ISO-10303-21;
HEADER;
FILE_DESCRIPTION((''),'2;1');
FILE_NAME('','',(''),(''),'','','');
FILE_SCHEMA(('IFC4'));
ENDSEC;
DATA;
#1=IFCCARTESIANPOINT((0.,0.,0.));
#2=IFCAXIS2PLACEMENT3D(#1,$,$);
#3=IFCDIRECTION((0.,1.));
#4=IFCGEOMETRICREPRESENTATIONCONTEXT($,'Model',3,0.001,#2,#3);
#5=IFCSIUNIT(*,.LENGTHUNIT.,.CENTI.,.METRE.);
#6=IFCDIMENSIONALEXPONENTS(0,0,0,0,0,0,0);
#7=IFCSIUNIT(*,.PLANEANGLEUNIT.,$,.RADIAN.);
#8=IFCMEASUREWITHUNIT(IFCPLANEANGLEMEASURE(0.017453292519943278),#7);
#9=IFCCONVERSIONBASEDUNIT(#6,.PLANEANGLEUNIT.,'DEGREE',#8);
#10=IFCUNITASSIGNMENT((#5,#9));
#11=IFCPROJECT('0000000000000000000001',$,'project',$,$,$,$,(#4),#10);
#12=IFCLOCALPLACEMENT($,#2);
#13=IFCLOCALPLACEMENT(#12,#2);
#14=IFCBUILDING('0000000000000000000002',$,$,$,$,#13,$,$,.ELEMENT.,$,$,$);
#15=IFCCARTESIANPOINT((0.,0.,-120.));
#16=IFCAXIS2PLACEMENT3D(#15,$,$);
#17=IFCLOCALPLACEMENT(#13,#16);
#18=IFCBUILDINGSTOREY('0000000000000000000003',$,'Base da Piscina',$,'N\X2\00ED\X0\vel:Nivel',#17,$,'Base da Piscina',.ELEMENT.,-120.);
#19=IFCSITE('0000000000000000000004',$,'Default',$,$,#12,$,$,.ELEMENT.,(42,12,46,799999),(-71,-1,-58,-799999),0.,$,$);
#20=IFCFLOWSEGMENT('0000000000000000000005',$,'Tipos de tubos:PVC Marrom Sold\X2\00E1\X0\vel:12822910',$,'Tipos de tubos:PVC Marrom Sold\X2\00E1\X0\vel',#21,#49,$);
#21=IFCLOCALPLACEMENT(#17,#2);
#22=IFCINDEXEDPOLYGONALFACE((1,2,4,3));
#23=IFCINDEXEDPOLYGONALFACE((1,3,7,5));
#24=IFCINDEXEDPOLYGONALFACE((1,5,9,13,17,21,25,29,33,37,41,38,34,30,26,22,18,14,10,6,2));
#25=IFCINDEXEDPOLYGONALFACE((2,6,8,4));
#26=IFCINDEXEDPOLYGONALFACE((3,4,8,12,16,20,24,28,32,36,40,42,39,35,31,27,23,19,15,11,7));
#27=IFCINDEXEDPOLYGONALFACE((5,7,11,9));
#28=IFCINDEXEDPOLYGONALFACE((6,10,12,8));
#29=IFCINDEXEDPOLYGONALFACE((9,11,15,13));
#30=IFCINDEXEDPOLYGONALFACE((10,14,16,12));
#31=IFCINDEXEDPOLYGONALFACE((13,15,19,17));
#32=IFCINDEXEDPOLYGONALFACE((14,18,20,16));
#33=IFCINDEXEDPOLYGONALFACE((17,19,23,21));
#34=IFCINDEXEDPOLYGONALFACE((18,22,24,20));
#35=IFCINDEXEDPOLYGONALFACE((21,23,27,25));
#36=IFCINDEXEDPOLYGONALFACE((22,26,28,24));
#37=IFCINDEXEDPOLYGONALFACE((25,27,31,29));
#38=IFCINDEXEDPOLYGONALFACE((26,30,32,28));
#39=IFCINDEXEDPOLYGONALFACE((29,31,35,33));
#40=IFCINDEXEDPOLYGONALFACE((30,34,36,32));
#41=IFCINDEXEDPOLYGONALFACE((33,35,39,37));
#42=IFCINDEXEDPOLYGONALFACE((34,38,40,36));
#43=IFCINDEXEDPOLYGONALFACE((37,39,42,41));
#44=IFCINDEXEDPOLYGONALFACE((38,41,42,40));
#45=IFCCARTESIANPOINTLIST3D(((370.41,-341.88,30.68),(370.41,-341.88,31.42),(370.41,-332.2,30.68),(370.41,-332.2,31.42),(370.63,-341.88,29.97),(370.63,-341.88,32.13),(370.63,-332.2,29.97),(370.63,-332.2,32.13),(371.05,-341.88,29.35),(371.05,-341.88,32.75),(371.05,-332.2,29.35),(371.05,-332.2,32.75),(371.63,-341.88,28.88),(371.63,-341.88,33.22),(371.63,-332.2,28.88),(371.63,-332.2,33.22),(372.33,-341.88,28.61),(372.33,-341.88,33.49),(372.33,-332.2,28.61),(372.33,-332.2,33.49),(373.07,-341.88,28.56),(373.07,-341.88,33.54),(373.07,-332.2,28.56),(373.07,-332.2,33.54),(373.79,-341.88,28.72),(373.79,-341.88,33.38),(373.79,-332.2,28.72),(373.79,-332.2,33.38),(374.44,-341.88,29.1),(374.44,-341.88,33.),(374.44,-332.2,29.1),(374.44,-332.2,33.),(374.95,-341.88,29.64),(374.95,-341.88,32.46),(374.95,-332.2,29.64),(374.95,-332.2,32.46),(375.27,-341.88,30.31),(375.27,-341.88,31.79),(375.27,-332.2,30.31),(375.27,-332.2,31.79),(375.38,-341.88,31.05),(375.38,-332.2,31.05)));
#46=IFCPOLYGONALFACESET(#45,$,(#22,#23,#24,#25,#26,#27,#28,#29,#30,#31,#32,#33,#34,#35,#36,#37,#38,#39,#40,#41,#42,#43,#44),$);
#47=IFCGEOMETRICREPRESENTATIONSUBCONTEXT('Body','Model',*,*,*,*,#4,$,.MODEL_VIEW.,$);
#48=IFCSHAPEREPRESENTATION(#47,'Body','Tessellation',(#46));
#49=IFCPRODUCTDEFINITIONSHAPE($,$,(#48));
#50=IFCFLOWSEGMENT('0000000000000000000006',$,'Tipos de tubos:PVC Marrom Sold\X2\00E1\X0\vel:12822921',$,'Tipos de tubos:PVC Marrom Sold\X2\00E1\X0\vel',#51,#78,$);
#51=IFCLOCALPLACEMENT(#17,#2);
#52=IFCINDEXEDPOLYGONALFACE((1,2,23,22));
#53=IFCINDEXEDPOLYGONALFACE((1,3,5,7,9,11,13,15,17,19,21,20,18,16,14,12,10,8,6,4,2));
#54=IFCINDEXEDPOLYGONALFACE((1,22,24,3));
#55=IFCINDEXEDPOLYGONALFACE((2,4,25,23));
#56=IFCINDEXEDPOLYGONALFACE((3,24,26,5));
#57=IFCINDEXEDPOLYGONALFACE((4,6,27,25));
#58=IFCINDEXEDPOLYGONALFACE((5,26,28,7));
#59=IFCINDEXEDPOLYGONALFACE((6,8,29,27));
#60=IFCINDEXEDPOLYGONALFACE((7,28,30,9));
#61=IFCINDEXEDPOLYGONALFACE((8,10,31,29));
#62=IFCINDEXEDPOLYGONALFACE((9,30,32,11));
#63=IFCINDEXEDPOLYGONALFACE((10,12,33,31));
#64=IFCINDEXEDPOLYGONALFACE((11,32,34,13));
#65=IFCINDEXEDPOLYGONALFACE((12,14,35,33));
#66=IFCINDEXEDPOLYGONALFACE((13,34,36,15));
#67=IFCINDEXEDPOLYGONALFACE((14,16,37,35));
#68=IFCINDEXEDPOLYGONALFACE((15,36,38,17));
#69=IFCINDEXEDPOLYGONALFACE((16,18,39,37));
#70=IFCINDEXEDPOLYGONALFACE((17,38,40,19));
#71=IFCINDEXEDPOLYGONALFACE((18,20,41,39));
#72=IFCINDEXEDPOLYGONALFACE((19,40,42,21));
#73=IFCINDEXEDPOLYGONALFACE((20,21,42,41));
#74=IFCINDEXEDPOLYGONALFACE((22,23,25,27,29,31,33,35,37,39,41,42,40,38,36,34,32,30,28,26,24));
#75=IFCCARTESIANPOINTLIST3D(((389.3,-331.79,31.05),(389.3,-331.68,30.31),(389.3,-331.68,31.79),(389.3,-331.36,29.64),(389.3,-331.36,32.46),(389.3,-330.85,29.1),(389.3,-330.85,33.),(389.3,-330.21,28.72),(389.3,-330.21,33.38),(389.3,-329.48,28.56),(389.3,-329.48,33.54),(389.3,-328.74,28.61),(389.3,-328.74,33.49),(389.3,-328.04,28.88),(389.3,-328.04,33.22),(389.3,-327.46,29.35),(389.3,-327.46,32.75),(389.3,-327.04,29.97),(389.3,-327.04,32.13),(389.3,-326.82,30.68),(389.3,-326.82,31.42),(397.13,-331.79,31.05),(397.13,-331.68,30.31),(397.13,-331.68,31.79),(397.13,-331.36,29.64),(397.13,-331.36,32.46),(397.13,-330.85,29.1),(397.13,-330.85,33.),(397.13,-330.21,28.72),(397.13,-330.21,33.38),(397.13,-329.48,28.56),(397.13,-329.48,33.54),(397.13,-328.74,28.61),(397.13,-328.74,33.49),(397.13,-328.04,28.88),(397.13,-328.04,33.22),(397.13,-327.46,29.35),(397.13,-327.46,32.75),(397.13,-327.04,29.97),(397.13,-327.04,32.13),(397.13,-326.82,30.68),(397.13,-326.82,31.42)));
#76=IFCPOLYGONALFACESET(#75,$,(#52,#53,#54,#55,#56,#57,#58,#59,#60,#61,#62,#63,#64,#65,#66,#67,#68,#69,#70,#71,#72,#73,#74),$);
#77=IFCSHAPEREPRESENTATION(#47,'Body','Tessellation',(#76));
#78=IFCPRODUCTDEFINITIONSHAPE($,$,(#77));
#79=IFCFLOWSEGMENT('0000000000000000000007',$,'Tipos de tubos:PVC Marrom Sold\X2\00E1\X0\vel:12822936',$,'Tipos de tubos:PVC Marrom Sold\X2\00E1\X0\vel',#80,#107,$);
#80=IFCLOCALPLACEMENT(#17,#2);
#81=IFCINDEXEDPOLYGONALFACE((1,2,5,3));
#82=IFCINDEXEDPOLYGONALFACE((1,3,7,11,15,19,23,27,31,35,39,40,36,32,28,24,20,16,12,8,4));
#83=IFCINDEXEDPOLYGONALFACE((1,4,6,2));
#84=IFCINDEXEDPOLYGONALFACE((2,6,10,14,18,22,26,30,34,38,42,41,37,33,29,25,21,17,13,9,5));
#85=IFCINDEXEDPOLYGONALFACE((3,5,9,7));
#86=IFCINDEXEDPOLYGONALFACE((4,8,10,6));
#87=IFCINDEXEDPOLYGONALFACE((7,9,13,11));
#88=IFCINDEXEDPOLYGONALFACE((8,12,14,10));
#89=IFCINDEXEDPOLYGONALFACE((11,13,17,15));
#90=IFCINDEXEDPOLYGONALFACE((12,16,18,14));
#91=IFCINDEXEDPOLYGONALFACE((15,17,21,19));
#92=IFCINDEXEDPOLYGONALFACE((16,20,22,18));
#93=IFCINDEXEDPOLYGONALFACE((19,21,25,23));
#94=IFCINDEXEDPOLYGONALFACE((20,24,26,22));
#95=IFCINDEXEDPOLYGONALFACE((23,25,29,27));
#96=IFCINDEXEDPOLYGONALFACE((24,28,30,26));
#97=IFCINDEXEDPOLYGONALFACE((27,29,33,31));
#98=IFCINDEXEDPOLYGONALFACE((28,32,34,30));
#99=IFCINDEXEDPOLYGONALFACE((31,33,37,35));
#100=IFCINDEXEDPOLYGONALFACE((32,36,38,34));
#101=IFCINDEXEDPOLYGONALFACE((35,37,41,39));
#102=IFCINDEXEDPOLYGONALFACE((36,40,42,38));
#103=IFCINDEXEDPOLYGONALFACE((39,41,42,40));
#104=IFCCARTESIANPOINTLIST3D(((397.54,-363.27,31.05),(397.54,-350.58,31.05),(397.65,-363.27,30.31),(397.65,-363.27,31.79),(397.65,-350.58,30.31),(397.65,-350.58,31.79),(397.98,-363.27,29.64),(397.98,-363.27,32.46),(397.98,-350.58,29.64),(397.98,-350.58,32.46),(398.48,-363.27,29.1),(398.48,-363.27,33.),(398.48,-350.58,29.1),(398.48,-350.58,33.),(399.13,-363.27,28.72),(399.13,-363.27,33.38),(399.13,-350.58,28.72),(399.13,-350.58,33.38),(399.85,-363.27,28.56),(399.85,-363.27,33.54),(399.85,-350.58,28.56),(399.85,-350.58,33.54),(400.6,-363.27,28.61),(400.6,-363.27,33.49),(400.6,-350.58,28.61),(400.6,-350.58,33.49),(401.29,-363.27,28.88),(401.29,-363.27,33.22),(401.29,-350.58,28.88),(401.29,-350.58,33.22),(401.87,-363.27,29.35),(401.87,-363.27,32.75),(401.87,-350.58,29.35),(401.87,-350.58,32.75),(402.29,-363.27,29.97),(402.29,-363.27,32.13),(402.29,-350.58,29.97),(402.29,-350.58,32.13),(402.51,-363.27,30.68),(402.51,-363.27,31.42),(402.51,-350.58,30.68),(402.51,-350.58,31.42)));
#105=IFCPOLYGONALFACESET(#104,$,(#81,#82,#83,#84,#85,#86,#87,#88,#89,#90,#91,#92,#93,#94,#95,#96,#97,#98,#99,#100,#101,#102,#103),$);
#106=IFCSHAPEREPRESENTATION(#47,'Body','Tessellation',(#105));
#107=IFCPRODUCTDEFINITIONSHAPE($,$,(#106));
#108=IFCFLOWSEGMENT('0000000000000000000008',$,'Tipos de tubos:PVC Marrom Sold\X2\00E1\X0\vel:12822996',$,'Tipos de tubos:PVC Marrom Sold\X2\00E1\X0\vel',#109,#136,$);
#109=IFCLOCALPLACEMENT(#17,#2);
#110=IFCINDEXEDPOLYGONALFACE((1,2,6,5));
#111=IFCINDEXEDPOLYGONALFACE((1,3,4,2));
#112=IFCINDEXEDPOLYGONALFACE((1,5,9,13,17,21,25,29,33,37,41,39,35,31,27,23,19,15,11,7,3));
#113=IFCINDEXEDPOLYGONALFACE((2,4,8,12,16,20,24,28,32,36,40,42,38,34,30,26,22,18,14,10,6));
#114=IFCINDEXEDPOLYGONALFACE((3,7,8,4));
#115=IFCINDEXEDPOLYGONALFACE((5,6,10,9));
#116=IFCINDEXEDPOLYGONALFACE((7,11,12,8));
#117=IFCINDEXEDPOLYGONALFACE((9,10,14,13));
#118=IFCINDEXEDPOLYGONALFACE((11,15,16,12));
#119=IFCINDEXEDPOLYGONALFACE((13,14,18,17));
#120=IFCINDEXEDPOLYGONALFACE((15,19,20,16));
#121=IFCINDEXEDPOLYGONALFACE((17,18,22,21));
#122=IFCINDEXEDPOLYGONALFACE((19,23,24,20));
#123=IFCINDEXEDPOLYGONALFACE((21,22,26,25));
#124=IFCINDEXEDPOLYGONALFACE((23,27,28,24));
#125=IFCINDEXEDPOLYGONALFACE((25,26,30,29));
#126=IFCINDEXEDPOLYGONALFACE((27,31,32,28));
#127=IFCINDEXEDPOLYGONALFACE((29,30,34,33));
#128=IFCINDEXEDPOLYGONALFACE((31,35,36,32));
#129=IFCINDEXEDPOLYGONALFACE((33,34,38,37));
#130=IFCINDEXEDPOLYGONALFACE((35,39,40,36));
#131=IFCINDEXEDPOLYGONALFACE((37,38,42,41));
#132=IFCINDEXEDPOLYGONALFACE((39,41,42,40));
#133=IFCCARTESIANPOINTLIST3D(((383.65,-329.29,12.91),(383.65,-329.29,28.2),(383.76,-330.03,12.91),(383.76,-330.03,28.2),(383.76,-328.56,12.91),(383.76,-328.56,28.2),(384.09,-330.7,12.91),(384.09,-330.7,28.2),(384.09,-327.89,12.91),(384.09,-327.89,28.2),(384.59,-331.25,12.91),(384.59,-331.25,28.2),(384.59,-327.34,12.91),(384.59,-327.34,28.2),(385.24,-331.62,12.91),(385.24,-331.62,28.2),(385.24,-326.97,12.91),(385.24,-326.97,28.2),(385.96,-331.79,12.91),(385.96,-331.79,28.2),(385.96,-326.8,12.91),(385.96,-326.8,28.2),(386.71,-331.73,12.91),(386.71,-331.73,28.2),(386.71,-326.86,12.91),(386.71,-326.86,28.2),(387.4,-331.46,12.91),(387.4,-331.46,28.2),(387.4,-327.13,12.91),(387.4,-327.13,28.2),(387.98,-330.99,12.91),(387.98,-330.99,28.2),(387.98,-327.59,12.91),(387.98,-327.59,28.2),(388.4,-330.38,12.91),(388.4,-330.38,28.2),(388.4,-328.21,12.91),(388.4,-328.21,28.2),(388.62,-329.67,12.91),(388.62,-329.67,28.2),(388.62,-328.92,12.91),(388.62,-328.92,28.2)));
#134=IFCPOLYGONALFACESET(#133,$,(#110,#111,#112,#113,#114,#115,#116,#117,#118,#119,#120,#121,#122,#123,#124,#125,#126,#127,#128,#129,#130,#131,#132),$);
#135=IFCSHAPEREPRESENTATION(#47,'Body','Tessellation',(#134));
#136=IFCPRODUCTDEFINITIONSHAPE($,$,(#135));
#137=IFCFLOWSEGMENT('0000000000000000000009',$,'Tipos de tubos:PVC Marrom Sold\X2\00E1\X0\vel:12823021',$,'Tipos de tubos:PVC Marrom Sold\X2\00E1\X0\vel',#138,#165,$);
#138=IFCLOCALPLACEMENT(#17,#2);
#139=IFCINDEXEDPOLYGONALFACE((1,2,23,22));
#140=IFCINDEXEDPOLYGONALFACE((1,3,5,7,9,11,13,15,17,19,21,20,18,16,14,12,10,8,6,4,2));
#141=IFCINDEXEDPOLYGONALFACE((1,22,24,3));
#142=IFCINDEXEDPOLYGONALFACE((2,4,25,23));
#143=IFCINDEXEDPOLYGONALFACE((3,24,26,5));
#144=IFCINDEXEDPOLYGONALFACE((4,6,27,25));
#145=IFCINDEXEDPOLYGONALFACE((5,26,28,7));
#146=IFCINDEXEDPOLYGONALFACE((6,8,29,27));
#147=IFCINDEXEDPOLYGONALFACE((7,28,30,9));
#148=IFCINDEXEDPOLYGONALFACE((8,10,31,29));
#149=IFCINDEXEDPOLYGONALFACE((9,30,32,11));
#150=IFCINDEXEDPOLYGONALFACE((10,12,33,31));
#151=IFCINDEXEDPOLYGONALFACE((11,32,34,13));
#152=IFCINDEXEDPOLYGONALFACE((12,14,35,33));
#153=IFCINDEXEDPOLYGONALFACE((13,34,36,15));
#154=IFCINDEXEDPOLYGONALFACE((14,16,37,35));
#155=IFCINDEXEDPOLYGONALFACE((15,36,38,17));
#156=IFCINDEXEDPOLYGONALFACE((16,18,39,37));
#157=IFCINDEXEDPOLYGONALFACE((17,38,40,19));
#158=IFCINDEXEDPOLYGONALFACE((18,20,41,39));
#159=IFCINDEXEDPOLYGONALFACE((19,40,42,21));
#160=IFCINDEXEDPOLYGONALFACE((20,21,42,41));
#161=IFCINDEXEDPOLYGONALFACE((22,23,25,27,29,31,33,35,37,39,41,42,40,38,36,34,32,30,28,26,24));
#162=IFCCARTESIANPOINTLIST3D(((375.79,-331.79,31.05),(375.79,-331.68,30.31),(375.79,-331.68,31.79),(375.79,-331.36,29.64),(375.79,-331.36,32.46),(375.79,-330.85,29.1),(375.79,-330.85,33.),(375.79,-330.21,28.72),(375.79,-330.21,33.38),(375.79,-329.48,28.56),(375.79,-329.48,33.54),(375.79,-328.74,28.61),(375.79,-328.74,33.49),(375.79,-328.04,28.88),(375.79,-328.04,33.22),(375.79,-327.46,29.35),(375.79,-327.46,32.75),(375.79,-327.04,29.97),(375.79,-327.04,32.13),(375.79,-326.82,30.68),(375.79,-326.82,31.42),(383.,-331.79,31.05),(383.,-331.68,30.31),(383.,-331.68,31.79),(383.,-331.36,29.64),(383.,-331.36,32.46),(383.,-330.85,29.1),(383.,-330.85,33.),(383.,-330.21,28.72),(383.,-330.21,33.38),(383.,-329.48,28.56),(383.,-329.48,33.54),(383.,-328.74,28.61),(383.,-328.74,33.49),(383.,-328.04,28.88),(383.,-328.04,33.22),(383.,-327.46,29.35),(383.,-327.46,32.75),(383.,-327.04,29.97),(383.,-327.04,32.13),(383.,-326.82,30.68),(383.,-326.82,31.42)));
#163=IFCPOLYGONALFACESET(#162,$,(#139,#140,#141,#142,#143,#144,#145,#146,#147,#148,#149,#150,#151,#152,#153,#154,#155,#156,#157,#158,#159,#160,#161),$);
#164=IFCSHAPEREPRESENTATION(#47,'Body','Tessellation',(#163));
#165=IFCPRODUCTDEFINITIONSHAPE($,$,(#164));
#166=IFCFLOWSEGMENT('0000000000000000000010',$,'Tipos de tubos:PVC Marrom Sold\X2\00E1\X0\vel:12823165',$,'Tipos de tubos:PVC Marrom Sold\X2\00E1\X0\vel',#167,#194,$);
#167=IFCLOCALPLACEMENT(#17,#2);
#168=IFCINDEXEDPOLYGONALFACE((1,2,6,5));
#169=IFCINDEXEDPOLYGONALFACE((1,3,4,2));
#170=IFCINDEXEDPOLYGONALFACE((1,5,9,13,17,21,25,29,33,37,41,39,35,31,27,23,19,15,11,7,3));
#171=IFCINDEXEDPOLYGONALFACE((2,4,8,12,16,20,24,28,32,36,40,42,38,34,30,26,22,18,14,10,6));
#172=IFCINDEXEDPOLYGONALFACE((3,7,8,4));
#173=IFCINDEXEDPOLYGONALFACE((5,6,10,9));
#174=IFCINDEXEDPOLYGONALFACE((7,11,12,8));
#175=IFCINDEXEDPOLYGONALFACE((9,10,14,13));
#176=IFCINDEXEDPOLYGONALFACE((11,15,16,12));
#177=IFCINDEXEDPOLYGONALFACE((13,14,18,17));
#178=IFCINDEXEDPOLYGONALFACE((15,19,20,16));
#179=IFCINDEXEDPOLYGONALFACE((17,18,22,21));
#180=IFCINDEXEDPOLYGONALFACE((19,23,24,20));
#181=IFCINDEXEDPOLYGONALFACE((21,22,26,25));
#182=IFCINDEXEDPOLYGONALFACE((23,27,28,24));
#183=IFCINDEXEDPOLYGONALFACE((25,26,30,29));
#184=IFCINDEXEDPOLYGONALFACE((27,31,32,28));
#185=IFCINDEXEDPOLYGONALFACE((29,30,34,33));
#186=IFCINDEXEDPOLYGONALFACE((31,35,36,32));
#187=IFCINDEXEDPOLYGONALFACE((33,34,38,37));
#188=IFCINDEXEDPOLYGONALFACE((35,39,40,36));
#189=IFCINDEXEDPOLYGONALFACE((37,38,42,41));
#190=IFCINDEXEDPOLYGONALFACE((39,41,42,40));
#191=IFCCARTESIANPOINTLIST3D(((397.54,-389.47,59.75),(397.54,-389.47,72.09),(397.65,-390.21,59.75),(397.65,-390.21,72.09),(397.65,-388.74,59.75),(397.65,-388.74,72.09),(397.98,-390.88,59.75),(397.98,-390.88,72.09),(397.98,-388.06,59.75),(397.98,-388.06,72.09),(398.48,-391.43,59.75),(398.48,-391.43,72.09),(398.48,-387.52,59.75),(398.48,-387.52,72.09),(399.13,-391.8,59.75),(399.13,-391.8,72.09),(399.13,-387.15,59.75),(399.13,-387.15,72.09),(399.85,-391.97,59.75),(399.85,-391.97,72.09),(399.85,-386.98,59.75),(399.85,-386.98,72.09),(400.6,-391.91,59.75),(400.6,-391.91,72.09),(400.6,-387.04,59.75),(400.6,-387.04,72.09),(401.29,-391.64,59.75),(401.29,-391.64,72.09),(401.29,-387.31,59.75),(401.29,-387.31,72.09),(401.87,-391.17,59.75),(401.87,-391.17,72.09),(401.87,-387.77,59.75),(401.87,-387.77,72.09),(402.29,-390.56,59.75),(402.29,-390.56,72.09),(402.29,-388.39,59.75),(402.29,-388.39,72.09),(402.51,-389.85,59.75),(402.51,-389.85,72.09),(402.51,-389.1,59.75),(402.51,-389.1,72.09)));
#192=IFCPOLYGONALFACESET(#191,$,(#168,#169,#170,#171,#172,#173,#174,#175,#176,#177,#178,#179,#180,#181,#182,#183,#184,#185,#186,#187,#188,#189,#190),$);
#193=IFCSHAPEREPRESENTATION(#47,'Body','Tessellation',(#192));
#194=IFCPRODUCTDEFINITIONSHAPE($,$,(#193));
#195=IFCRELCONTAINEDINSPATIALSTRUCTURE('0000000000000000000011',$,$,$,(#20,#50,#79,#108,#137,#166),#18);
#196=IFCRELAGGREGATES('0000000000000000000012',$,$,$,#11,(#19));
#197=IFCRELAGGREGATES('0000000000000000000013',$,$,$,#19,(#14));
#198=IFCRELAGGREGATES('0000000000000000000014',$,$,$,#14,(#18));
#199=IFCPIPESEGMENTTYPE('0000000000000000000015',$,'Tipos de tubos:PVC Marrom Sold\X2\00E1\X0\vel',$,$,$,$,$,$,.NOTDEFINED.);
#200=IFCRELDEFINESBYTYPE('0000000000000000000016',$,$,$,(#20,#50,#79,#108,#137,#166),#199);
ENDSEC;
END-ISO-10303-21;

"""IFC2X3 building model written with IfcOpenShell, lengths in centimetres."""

from ifc_helpers import new_model, entity, si_unit, converted_unit, direction, frame, frame_2d, origin, origin_2d_with_axis, place, context, subcontext, project, spatial, circle, extrude, type_object, element, save


model = new_model("IFC2X3")

# Units and contexts
model_context = context("Model", 3, precision=0.001, world=origin(), true_north=direction((0.0, 1.0)))
body_context = subcontext(model_context, "Body", "Model", "MODEL_VIEW")
ifc_project = project(units=[si_unit("LENGTHUNIT", "METRE", prefix="CENTI"), converted_unit("PLANEANGLEUNIT", "DEGREE", entity("IfcPlaneAngleMeasure", 0.017453292519943278), si_unit("PLANEANGLEUNIT", "RADIAN"), dimensions=[0, 0, 0, 0, 0, 0, 0])], contexts=[model_context])

# Site, building, storey
site_placement = place(None, origin())
site = spatial("IfcSite", under=ifc_project, at=site_placement, Name="Default", CompositionType="ELEMENT", RefLatitude=(42, 12, 46, 799999), RefLongitude=(-71, -1, -58, -799999), RefElevation=0.0)
building_placement = place(site_placement, origin())
building = spatial("IfcBuilding", under=site, at=building_placement, CompositionType="ELEMENT")
storey_placement = place(building_placement, frame((0.0, 0.0, -120.0)))
storey = spatial("IfcBuildingStorey", under=building, at=storey_placement, Name="Base da Piscina", ObjectType="Nível:Nivel", LongName="Base da Piscina", CompositionType="ELEMENT", Elevation=-120.0)

# Flow segments
pipe_segment_type = type_object("IfcPipeSegmentType", Name="Tipos de tubos:PVC Marrom Soldável", PredefinedType="NOTDEFINED")
flow_segment_1_placement = place(storey_placement, origin())
element("IfcFlowSegment", 1, at=flow_segment_1_placement, inside=storey, type_object=pipe_segment_type, Name="Tipos de tubos:PVC Marrom Soldável:12822910", ObjectType="Tipos de tubos:PVC Marrom Soldável", context=body_context, shape_type="SweptSolid", body=[
    extrude(circle(Radius=2.5, at=origin_2d_with_axis()), frame((372.88, -341.88, 31.05), z_axis=(0.0, 1.0, 0.0), x_axis=(1.0, 0.0, 0.0)), (0.0, 0.0, 1.0), 9.68),
])
flow_segment_2_placement = place(storey_placement, origin())
element("IfcFlowSegment", 2, at=flow_segment_2_placement, inside=storey, type_object=pipe_segment_type, Name="Tipos de tubos:PVC Marrom Soldável:12822921", ObjectType="Tipos de tubos:PVC Marrom Soldável", context=body_context, shape_type="SweptSolid", body=[
    extrude(circle(Radius=2.5, at=origin_2d_with_axis()), frame((389.3, -329.29, 31.05), z_axis=(1.0, 0.0, 0.0), x_axis=(0.0, -1.0, 0.0)), (0.0, 0.0, 1.0), 7.83),
])
flow_segment_3_placement = place(storey_placement, origin())
element("IfcFlowSegment", 3, at=flow_segment_3_placement, inside=storey, type_object=pipe_segment_type, Name="Tipos de tubos:PVC Marrom Soldável:12822936", ObjectType="Tipos de tubos:PVC Marrom Soldável", context=body_context, shape_type="SweptSolid", body=[
    extrude(circle(Radius=2.5, at=frame_2d((0.0, 0.0), x_axis=(1.0, 0.0))), frame((400.04, -363.27, 31.05), z_axis=(0.0, 1.0, 0.0), x_axis=(-1.0, 0.0, 0.0)), (0.0, 0.0, 1.0), 12.69),
])
flow_segment_4_placement = place(storey_placement, origin())
element("IfcFlowSegment", 4, at=flow_segment_4_placement, inside=storey, type_object=pipe_segment_type, Name="Tipos de tubos:PVC Marrom Soldável:12822996", ObjectType="Tipos de tubos:PVC Marrom Soldável", context=body_context, shape_type="SweptSolid", body=[
    extrude(circle(Radius=2.5, at=origin_2d_with_axis()), frame((386.15, -329.29, 12.91), z_axis=(0.0, 0.0, 1.0), x_axis=(-1.0, 0.0, 0.0)), (0.0, 0.0, 1.0), 15.29),
])
flow_segment_5_placement = place(storey_placement, origin())
element("IfcFlowSegment", 5, at=flow_segment_5_placement, inside=storey, type_object=pipe_segment_type, Name="Tipos de tubos:PVC Marrom Soldável:12823021", ObjectType="Tipos de tubos:PVC Marrom Soldável", context=body_context, shape_type="SweptSolid", body=[
    extrude(circle(Radius=2.5, at=origin_2d_with_axis()), frame((375.79, -329.29, 31.05), z_axis=(1.0, 0.0, 0.0), x_axis=(0.0, -1.0, 0.0)), (0.0, 0.0, 1.0), 7.21),
])
flow_segment_6_placement = place(storey_placement, origin())
element("IfcFlowSegment", 6, at=flow_segment_6_placement, inside=storey, type_object=pipe_segment_type, Name="Tipos de tubos:PVC Marrom Soldável:12823165", ObjectType="Tipos de tubos:PVC Marrom Soldável", context=body_context, shape_type="SweptSolid", body=[
    extrude(circle(Radius=2.5, at=frame_2d((0.0, 0.0), x_axis=(1.0, 0.0))), frame((400.04, -389.47, 59.75), z_axis=(0.0, 0.0, 1.0), x_axis=(-1.0, 0.0, 0.0)), (0.0, 0.0, 1.0), 12.34),
])

save(model, "model.ifc")
